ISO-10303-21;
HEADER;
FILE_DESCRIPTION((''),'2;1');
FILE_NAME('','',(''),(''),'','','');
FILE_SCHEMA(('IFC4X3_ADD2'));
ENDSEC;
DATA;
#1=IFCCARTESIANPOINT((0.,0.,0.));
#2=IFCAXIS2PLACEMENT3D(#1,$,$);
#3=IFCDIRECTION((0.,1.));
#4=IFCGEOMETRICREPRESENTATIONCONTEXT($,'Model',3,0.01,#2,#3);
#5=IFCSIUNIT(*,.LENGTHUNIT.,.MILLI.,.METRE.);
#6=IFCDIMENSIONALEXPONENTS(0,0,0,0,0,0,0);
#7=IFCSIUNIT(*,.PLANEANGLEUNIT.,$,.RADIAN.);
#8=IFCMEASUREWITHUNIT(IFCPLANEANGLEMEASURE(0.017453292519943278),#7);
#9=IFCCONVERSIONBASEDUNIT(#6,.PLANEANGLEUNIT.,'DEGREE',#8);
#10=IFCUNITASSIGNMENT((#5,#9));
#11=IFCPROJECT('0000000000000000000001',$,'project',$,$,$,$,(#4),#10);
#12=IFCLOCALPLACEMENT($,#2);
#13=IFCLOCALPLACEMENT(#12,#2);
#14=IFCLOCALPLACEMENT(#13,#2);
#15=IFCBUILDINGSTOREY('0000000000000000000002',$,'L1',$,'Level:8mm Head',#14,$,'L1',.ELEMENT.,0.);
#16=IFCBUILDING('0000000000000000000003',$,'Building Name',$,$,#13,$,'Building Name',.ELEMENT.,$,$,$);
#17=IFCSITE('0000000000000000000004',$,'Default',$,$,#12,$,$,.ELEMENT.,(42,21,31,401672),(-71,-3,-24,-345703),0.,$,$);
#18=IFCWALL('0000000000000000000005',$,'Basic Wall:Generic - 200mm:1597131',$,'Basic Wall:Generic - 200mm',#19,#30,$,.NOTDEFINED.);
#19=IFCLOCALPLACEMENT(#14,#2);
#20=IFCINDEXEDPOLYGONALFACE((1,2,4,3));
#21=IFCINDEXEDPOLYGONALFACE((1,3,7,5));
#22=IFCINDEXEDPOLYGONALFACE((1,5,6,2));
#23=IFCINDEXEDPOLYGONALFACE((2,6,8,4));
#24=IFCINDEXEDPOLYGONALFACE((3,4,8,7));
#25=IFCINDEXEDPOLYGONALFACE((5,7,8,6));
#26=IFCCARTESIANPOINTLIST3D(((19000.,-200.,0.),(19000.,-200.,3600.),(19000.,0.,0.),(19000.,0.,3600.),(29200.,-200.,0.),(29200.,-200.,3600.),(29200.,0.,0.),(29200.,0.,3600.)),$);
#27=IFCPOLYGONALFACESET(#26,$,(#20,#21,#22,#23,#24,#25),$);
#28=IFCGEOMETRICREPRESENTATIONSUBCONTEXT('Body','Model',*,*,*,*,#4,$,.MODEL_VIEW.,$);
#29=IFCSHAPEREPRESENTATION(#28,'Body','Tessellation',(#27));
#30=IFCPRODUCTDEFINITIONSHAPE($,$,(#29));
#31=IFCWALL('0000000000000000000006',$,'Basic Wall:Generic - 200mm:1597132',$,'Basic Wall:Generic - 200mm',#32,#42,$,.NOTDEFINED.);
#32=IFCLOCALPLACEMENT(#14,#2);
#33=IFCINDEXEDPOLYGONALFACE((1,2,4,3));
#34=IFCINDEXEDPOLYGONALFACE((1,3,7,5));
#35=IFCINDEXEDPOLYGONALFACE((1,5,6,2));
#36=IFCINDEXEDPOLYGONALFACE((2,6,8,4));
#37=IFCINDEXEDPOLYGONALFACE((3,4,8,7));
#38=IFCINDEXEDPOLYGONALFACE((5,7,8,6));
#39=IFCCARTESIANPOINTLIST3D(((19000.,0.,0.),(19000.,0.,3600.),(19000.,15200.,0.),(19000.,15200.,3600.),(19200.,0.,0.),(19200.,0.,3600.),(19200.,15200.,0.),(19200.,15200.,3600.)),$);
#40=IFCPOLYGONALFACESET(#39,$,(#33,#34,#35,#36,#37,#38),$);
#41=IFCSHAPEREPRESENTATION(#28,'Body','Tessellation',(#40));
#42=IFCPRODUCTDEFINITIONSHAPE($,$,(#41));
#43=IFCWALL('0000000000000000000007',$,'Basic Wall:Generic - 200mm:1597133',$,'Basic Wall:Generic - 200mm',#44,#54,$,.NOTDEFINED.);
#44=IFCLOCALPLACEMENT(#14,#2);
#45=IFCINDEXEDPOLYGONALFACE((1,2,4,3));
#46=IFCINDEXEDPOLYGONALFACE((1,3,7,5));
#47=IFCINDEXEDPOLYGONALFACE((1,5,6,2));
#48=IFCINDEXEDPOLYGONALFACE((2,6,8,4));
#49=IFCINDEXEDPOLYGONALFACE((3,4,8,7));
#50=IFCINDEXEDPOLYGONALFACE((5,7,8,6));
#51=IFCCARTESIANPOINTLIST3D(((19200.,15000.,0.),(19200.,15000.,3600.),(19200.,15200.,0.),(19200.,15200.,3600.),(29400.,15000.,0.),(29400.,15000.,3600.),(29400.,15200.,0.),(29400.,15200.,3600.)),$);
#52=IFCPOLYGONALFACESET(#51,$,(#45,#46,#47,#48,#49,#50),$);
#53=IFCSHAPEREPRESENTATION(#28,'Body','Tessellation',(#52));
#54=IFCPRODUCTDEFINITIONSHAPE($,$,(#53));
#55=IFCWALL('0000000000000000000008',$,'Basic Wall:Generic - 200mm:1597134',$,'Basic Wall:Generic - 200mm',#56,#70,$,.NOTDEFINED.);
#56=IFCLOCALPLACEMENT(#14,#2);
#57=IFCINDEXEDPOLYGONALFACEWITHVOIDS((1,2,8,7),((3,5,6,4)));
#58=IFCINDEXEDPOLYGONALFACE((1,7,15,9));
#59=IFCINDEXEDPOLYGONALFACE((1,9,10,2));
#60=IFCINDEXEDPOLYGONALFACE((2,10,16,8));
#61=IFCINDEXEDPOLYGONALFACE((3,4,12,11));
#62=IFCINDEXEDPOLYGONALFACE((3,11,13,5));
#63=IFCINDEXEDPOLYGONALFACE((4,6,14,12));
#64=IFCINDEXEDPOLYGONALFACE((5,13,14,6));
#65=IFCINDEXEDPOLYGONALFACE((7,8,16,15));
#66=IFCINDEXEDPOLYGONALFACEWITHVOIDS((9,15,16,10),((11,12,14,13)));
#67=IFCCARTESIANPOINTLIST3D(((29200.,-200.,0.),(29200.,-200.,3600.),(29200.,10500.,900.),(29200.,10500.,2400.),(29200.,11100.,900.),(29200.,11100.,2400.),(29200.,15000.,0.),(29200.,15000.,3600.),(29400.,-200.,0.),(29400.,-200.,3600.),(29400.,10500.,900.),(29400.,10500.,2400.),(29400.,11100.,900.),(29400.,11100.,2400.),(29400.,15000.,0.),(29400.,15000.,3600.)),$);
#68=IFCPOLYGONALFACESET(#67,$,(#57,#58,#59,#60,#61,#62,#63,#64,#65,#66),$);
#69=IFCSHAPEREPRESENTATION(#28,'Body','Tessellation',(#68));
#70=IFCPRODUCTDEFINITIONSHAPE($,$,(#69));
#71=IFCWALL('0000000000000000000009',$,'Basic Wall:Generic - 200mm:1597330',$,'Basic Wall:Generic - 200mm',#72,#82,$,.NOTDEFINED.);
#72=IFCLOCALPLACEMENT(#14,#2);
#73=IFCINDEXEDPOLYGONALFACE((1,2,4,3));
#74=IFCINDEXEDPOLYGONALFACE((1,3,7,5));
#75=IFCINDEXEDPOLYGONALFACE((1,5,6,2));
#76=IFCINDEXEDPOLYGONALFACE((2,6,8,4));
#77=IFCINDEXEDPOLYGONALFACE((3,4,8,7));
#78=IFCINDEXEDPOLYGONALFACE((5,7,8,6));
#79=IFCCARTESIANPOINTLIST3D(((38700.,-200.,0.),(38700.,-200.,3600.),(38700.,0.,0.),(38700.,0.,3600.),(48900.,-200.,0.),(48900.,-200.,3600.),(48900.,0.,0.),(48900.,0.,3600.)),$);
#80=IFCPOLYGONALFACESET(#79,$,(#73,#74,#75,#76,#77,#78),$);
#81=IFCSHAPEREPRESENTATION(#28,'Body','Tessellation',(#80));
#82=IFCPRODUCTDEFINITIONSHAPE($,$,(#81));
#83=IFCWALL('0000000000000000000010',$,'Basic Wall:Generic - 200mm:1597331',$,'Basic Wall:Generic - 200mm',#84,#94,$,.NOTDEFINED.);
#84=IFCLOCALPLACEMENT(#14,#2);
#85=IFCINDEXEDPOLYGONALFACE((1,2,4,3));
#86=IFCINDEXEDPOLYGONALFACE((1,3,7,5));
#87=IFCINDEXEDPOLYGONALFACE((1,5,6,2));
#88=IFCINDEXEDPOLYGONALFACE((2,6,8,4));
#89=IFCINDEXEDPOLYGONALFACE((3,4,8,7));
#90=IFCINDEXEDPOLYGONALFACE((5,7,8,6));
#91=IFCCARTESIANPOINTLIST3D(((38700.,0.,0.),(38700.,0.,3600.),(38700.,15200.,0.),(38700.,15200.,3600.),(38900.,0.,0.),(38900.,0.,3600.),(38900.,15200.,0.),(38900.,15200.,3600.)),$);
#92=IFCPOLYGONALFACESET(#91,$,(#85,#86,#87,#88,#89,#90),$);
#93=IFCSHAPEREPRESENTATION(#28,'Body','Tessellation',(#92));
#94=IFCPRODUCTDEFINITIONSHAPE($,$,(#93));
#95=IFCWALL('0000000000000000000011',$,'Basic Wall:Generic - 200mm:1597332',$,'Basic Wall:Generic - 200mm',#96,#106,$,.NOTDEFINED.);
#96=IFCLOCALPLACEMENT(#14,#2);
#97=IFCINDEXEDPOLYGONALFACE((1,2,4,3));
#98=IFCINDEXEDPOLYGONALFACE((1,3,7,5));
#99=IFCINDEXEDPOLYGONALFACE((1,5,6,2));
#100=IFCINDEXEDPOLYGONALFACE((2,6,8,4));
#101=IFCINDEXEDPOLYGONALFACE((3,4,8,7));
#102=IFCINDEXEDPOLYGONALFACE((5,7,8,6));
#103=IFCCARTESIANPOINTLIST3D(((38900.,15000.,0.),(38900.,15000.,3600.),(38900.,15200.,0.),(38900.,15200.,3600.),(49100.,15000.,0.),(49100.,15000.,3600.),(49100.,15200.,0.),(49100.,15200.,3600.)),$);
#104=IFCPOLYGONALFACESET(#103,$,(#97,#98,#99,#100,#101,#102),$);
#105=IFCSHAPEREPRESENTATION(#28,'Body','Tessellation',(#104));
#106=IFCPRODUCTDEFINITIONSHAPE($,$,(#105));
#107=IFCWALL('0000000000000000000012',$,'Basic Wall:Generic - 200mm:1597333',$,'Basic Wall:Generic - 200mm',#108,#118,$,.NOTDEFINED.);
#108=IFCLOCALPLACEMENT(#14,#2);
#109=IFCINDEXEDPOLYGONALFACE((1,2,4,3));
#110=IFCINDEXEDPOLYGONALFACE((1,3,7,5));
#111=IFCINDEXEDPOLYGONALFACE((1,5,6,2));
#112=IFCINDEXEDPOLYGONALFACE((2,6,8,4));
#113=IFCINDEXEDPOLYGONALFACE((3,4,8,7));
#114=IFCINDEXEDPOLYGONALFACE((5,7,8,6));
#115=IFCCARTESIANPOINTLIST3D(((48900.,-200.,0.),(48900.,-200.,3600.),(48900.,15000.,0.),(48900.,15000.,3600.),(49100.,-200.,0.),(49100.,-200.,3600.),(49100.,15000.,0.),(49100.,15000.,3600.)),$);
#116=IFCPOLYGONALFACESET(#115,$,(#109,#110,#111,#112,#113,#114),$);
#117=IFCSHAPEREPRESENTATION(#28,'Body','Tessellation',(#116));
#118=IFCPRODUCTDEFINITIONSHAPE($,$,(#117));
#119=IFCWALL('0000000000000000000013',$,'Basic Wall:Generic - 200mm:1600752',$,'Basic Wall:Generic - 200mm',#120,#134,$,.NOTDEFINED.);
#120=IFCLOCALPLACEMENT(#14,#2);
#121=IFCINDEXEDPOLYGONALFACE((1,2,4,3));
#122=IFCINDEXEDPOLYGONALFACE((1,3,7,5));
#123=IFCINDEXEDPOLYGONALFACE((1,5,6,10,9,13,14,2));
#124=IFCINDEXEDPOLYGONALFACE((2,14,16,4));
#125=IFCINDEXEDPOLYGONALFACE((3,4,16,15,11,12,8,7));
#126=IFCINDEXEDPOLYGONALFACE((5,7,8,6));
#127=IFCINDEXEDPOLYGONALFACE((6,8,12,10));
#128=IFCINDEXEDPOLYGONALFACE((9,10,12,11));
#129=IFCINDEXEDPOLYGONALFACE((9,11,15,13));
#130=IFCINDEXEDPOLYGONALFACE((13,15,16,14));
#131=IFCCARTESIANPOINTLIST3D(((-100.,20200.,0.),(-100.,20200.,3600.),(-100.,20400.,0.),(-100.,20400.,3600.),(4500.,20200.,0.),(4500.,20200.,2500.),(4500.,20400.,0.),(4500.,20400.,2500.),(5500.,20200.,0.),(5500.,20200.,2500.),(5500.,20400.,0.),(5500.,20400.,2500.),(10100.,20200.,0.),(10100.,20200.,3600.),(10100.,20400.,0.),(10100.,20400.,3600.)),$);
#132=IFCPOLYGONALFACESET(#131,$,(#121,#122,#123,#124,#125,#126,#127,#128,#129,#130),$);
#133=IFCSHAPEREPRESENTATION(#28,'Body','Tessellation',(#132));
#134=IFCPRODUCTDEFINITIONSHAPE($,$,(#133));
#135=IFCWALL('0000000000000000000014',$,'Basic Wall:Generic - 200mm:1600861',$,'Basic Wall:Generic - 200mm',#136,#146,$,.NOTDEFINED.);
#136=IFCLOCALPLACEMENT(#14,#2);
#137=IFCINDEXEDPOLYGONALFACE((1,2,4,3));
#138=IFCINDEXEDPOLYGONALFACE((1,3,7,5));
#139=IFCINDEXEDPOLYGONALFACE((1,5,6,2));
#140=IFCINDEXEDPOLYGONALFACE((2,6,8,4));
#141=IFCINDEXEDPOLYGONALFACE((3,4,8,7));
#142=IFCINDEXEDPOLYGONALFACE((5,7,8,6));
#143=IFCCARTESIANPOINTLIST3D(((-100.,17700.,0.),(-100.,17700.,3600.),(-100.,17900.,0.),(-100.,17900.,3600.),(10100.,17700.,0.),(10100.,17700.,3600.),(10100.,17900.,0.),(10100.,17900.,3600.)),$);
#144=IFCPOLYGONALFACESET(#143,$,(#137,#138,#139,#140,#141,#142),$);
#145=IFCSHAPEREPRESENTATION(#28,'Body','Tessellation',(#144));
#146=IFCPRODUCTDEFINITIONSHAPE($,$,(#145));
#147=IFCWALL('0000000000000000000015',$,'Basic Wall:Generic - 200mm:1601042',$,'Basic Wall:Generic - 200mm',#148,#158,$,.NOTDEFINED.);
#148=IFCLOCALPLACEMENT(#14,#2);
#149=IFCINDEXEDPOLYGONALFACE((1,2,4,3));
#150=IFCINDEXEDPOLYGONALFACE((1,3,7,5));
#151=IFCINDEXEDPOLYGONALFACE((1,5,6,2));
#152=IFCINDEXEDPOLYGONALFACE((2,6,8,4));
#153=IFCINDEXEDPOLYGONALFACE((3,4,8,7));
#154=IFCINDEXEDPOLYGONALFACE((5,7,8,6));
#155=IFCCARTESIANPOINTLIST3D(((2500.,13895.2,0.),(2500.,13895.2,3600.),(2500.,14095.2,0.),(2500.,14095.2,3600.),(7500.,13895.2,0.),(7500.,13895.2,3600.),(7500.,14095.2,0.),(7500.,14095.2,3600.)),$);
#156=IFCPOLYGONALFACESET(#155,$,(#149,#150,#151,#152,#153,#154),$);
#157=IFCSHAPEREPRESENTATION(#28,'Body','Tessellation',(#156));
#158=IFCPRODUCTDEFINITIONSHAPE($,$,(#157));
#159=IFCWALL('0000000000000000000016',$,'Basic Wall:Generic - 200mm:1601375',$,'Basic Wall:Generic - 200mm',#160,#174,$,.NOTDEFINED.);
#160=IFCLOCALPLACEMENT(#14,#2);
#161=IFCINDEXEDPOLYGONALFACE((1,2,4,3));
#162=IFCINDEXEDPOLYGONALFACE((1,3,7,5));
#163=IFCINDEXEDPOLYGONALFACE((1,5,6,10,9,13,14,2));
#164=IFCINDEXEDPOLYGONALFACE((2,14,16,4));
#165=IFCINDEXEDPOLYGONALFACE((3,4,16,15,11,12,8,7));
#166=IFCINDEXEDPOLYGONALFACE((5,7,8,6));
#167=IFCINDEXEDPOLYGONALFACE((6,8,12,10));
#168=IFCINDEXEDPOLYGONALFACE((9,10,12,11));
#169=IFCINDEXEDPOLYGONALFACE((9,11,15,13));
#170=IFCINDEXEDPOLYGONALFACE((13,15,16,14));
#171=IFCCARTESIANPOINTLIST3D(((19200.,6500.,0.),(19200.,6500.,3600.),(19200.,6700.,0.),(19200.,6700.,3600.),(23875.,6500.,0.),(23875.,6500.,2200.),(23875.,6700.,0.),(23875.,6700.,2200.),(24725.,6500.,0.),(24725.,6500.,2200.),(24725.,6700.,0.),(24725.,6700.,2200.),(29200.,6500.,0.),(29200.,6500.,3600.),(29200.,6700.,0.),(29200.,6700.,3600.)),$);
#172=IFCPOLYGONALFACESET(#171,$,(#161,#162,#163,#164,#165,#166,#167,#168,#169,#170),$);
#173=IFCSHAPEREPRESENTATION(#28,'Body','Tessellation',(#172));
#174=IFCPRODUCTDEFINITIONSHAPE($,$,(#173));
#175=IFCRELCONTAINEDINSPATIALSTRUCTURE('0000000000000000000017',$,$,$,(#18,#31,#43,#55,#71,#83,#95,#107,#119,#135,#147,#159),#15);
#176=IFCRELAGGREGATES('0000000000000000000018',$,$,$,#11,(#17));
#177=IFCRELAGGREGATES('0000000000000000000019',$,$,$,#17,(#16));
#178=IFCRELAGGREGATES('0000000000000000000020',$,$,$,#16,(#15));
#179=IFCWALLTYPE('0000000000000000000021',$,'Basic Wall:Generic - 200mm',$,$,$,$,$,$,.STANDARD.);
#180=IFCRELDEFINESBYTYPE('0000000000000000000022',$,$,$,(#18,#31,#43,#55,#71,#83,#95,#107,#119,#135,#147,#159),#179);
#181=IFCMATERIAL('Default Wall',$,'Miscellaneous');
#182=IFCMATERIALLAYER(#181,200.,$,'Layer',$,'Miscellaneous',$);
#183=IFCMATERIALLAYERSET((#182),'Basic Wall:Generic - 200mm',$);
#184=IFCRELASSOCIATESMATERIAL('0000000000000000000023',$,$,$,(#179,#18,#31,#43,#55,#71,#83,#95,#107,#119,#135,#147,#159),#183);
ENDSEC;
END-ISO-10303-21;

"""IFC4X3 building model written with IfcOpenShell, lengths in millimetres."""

from ifc_helpers import new_model, entity, si_unit, converted_unit, direction, frame, frame_2d, origin, origin_2d_with_axis, place, context, subcontext, project, spatial, rectangle, extrude, material, layer, layer_set, type_object, element, save


model = new_model("IFC4X3")

# Units and contexts
model_context = context("Model", 3, precision=0.01, world=origin(), true_north=direction((0.0, 1.0)))
body_context = subcontext(model_context, "Body", "Model", "MODEL_VIEW")
ifc_project = project(units=[si_unit("LENGTHUNIT", "METRE", prefix="MILLI"), converted_unit("PLANEANGLEUNIT", "DEGREE", entity("IfcPlaneAngleMeasure", 0.017453292519943278), si_unit("PLANEANGLEUNIT", "RADIAN"), dimensions=[0, 0, 0, 0, 0, 0, 0])], contexts=[model_context])

# Site, building, storey
site_placement = place(None, origin())
site = spatial("IfcSite", under=ifc_project, at=site_placement, Name="Default", CompositionType="ELEMENT", RefLatitude=(42, 21, 31, 401672), RefLongitude=(-71, -3, -24, -345703), RefElevation=0.0)
building_placement = place(site_placement, origin())
building = spatial("IfcBuilding", under=site, at=building_placement, Name="Building Name", LongName="Building Name", CompositionType="ELEMENT")
storey_placement = place(building_placement, origin())
storey = spatial("IfcBuildingStorey", under=building, at=storey_placement, Name="L1", ObjectType="Level:8mm Head", LongName="L1", CompositionType="ELEMENT", Elevation=0.0)

# Walls
ifc_material_1 = material(Name="Default Wall", Category="Miscellaneous")
ifc_layer_1 = layer(ifc_material_1, 200.0, Name="Layer", Category="Miscellaneous")
ifc_layer_set_1 = layer_set([ifc_layer_1], Name="Basic Wall:Generic - 200mm")
wall_type_1 = type_object("IfcWallType", Name="Basic Wall:Generic - 200mm", PredefinedType="STANDARD", material=ifc_layer_set_1)
wall_1_placement = place(storey_placement, frame((19000.0, -100.0, 0.0)))
element("IfcWall", 1, at=wall_1_placement, inside=storey, type_object=wall_type_1, material=ifc_layer_set_1, Name="Basic Wall:Generic - 200mm:1597131", ObjectType="Basic Wall:Generic - 200mm", PredefinedType="NOTDEFINED", context=body_context, shape_type="SweptSolid", body=[
    extrude(rectangle(XDim=10200.0, YDim=200.0, at=frame_2d((5100.0, 0.0), x_axis=(-1.0, 0.0))), origin(), (0.0, 0.0, 1.0), 3600.0),
])
wall_2_placement = place(storey_placement, frame((19100.0, 15200.0, 0.0), z_axis=(0.0, 0.0, 1.0), x_axis=(0.0, -1.0, 0.0)))
element("IfcWall", 2, at=wall_2_placement, inside=storey, type_object=wall_type_1, material=ifc_layer_set_1, Name="Basic Wall:Generic - 200mm:1597132", ObjectType="Basic Wall:Generic - 200mm", PredefinedType="NOTDEFINED", context=body_context, shape_type="SweptSolid", body=[
    extrude(rectangle(XDim=15200.0, YDim=200.0, at=frame_2d((7600.0, 0.0), x_axis=(-1.0, 0.0))), origin(), (0.0, 0.0, 1.0), 3600.0),
])
wall_3_placement = place(storey_placement, frame((29400.0, 15100.0, 0.0), z_axis=(0.0, 0.0, 1.0), x_axis=(-1.0, 0.0, 0.0)))
element("IfcWall", 3, at=wall_3_placement, inside=storey, type_object=wall_type_1, material=ifc_layer_set_1, Name="Basic Wall:Generic - 200mm:1597133", ObjectType="Basic Wall:Generic - 200mm", PredefinedType="NOTDEFINED", context=body_context, shape_type="SweptSolid", body=[
    extrude(rectangle(XDim=10200.0, YDim=200.0, at=frame_2d((5100.0, 0.0), x_axis=(-1.0, 0.0))), origin(), (0.0, 0.0, 1.0), 3600.0),
])

# Wall, opening
wall_4_placement = place(storey_placement, frame((29300.0, -200.0, 0.0), z_axis=(0.0, 0.0, 1.0), x_axis=(0.0, 1.0, 0.0)))
wall_4 = element("IfcWall", 4, at=wall_4_placement, inside=storey, type_object=wall_type_1, material=ifc_layer_set_1, Name="Basic Wall:Generic - 200mm:1597134", ObjectType="Basic Wall:Generic - 200mm", PredefinedType="NOTDEFINED", context=body_context, shape_type="SweptSolid", body=[
    extrude(rectangle(XDim=15200.0, YDim=200.0, at=frame_2d((7600.0, 0.0), x_axis=(-1.0, 0.0))), origin(), (0.0, 0.0, 1.0), 3600.0),
])
opening_1_placement = place(wall_4_placement, frame((11300.0, 100.0, 900.0)))
element("IfcOpeningElement", 5, at=opening_1_placement, cuts=wall_4, PredefinedType="OPENING", context=body_context, shape_type="SweptSolid", body=[
    extrude(rectangle(XDim=1500.0, YDim=600.0, at=frame_2d((750.0, 300.0), x_axis=(-1.0, 0.0))), frame((0.0, 0.0, 0.0), z_axis=(0.0, -1.0, 0.0), x_axis=(0.0, 0.0, 1.0)), (0.0, 0.0, 1.0), 200.0),
])

# Walls
wall_5_placement = place(storey_placement, frame((38700.0, -100.0, 0.0)))
element("IfcWall", 6, at=wall_5_placement, inside=storey, type_object=wall_type_1, material=ifc_layer_set_1, Name="Basic Wall:Generic - 200mm:1597330", ObjectType="Basic Wall:Generic - 200mm", PredefinedType="NOTDEFINED", context=body_context, shape_type="SweptSolid", body=[
    extrude(rectangle(XDim=10200.0, YDim=200.0, at=frame_2d((5100.0, 0.0), x_axis=(-1.0, 0.0))), origin(), (0.0, 0.0, 1.0), 3600.0),
])
wall_6_placement = place(storey_placement, frame((38800.0, 15200.0, 0.0), z_axis=(0.0, 0.0, 1.0), x_axis=(0.0, -1.0, 0.0)))
element("IfcWall", 7, at=wall_6_placement, inside=storey, type_object=wall_type_1, material=ifc_layer_set_1, Name="Basic Wall:Generic - 200mm:1597331", ObjectType="Basic Wall:Generic - 200mm", PredefinedType="NOTDEFINED", context=body_context, shape_type="SweptSolid", body=[
    extrude(rectangle(XDim=15200.0, YDim=200.0, at=frame_2d((7600.0, 0.0), x_axis=(-1.0, 0.0))), origin(), (0.0, 0.0, 1.0), 3600.0),
])
wall_7_placement = place(storey_placement, frame((49100.0, 15100.0, 0.0), z_axis=(0.0, 0.0, 1.0), x_axis=(-1.0, 0.0, 0.0)))
element("IfcWall", 8, at=wall_7_placement, inside=storey, type_object=wall_type_1, material=ifc_layer_set_1, Name="Basic Wall:Generic - 200mm:1597332", ObjectType="Basic Wall:Generic - 200mm", PredefinedType="NOTDEFINED", context=body_context, shape_type="SweptSolid", body=[
    extrude(rectangle(XDim=10200.0, YDim=200.0, at=frame_2d((5100.0, 0.0), x_axis=(-1.0, 0.0))), origin(), (0.0, 0.0, 1.0), 3600.0),
])
wall_8_placement = place(storey_placement, frame((49000.0, -200.0, 0.0), z_axis=(0.0, 0.0, 1.0), x_axis=(0.0, 1.0, 0.0)))
element("IfcWall", 9, at=wall_8_placement, inside=storey, type_object=wall_type_1, material=ifc_layer_set_1, Name="Basic Wall:Generic - 200mm:1597333", ObjectType="Basic Wall:Generic - 200mm", PredefinedType="NOTDEFINED", context=body_context, shape_type="SweptSolid", body=[
    extrude(rectangle(XDim=15200.0, YDim=200.0, at=frame_2d((7600.0, 0.0), x_axis=(-1.0, 0.0))), origin(), (0.0, 0.0, 1.0), 3600.0),
])

# Wall, opening
wall_9_placement = place(storey_placement, frame((10100.0, 20300.0, 0.0), z_axis=(0.0, 0.0, 1.0), x_axis=(-1.0, 0.0, 0.0)))
wall_9 = element("IfcWall", 10, at=wall_9_placement, inside=storey, type_object=wall_type_1, material=ifc_layer_set_1, Name="Basic Wall:Generic - 200mm:1600752", ObjectType="Basic Wall:Generic - 200mm", PredefinedType="NOTDEFINED", context=body_context, shape_type="SweptSolid", body=[
    extrude(rectangle(XDim=10200.0, YDim=200.0, at=frame_2d((5100.0, 0.0), x_axis=(1.0, 0.0))), origin(), (0.0, 0.0, 1.0), 3600.0),
])
opening_2_placement = place(wall_9_placement, frame((5600.0, 100.0, 0.0)))
element("IfcOpeningElement", 11, at=opening_2_placement, cuts=wall_9, PredefinedType="OPENING", context=body_context, shape_type="SweptSolid", body=[
    extrude(rectangle(XDim=2500.0, YDim=1000.0, at=origin_2d_with_axis()), frame((-500.0, -200.0, 1250.0), z_axis=(0.0, 1.0, 0.0), x_axis=(0.0, 0.0, -1.0)), (0.0, 0.0, 1.0), 200.0),
])

# Walls
wall_10_placement = place(storey_placement, frame((10100.0, 17800.0, 0.0), z_axis=(0.0, 0.0, 1.0), x_axis=(-1.0, 0.0, 0.0)))
element("IfcWall", 12, at=wall_10_placement, inside=storey, type_object=wall_type_1, material=ifc_layer_set_1, Name="Basic Wall:Generic - 200mm:1600861", ObjectType="Basic Wall:Generic - 200mm", PredefinedType="NOTDEFINED", context=body_context, shape_type="SweptSolid", body=[
    extrude(rectangle(XDim=10200.0, YDim=200.0, at=frame_2d((5100.0, 0.0), x_axis=(-1.0, 0.0))), origin(), (0.0, 0.0, 1.0), 3600.0),
])
wall_11_placement = place(storey_placement, frame((7500.0, 13995.2, 0.0), z_axis=(0.0, 0.0, 1.0), x_axis=(-1.0, 0.0, 0.0)))
element("IfcWall", 13, at=wall_11_placement, inside=storey, type_object=wall_type_1, material=ifc_layer_set_1, Name="Basic Wall:Generic - 200mm:1601042", ObjectType="Basic Wall:Generic - 200mm", PredefinedType="NOTDEFINED", context=body_context, shape_type="SweptSolid", body=[
    extrude(rectangle(XDim=5000.0, YDim=200.0, at=frame_2d((2500.0, 0.0), x_axis=(-1.0, 0.0))), origin(), (0.0, 0.0, 1.0), 3600.0),
])

# Wall, opening
wall_12_placement = place(storey_placement, frame((29200.0, 6600.0, 0.0), z_axis=(0.0, 0.0, 1.0), x_axis=(-1.0, 0.0, 0.0)))
wall_12 = element("IfcWall", 14, at=wall_12_placement, inside=storey, type_object=wall_type_1, material=ifc_layer_set_1, Name="Basic Wall:Generic - 200mm:1601375", ObjectType="Basic Wall:Generic - 200mm", PredefinedType="NOTDEFINED", context=body_context, shape_type="SweptSolid", body=[
    extrude(rectangle(XDim=10000.0, YDim=200.0, at=frame_2d((5000.0, 0.0), x_axis=(1.0, 0.0))), origin(), (0.0, 0.0, 1.0), 3600.0),
])
opening_3_placement = place(wall_12_placement, frame((5325.0, 100.0, 0.0)))
element("IfcOpeningElement", 15, at=opening_3_placement, cuts=wall_12, PredefinedType="OPENING", context=body_context, shape_type="SweptSolid", body=[
    extrude(rectangle(XDim=2200.0, YDim=850.0, at=frame_2d((1100.0, 425.0), x_axis=(1.0, 0.0))), frame((0.0, 0.0, 0.0), z_axis=(0.0, -1.0, 0.0), x_axis=(0.0, 0.0, 1.0)), (0.0, 0.0, 1.0), 200.0),
])

save(model, "model.ifc")
